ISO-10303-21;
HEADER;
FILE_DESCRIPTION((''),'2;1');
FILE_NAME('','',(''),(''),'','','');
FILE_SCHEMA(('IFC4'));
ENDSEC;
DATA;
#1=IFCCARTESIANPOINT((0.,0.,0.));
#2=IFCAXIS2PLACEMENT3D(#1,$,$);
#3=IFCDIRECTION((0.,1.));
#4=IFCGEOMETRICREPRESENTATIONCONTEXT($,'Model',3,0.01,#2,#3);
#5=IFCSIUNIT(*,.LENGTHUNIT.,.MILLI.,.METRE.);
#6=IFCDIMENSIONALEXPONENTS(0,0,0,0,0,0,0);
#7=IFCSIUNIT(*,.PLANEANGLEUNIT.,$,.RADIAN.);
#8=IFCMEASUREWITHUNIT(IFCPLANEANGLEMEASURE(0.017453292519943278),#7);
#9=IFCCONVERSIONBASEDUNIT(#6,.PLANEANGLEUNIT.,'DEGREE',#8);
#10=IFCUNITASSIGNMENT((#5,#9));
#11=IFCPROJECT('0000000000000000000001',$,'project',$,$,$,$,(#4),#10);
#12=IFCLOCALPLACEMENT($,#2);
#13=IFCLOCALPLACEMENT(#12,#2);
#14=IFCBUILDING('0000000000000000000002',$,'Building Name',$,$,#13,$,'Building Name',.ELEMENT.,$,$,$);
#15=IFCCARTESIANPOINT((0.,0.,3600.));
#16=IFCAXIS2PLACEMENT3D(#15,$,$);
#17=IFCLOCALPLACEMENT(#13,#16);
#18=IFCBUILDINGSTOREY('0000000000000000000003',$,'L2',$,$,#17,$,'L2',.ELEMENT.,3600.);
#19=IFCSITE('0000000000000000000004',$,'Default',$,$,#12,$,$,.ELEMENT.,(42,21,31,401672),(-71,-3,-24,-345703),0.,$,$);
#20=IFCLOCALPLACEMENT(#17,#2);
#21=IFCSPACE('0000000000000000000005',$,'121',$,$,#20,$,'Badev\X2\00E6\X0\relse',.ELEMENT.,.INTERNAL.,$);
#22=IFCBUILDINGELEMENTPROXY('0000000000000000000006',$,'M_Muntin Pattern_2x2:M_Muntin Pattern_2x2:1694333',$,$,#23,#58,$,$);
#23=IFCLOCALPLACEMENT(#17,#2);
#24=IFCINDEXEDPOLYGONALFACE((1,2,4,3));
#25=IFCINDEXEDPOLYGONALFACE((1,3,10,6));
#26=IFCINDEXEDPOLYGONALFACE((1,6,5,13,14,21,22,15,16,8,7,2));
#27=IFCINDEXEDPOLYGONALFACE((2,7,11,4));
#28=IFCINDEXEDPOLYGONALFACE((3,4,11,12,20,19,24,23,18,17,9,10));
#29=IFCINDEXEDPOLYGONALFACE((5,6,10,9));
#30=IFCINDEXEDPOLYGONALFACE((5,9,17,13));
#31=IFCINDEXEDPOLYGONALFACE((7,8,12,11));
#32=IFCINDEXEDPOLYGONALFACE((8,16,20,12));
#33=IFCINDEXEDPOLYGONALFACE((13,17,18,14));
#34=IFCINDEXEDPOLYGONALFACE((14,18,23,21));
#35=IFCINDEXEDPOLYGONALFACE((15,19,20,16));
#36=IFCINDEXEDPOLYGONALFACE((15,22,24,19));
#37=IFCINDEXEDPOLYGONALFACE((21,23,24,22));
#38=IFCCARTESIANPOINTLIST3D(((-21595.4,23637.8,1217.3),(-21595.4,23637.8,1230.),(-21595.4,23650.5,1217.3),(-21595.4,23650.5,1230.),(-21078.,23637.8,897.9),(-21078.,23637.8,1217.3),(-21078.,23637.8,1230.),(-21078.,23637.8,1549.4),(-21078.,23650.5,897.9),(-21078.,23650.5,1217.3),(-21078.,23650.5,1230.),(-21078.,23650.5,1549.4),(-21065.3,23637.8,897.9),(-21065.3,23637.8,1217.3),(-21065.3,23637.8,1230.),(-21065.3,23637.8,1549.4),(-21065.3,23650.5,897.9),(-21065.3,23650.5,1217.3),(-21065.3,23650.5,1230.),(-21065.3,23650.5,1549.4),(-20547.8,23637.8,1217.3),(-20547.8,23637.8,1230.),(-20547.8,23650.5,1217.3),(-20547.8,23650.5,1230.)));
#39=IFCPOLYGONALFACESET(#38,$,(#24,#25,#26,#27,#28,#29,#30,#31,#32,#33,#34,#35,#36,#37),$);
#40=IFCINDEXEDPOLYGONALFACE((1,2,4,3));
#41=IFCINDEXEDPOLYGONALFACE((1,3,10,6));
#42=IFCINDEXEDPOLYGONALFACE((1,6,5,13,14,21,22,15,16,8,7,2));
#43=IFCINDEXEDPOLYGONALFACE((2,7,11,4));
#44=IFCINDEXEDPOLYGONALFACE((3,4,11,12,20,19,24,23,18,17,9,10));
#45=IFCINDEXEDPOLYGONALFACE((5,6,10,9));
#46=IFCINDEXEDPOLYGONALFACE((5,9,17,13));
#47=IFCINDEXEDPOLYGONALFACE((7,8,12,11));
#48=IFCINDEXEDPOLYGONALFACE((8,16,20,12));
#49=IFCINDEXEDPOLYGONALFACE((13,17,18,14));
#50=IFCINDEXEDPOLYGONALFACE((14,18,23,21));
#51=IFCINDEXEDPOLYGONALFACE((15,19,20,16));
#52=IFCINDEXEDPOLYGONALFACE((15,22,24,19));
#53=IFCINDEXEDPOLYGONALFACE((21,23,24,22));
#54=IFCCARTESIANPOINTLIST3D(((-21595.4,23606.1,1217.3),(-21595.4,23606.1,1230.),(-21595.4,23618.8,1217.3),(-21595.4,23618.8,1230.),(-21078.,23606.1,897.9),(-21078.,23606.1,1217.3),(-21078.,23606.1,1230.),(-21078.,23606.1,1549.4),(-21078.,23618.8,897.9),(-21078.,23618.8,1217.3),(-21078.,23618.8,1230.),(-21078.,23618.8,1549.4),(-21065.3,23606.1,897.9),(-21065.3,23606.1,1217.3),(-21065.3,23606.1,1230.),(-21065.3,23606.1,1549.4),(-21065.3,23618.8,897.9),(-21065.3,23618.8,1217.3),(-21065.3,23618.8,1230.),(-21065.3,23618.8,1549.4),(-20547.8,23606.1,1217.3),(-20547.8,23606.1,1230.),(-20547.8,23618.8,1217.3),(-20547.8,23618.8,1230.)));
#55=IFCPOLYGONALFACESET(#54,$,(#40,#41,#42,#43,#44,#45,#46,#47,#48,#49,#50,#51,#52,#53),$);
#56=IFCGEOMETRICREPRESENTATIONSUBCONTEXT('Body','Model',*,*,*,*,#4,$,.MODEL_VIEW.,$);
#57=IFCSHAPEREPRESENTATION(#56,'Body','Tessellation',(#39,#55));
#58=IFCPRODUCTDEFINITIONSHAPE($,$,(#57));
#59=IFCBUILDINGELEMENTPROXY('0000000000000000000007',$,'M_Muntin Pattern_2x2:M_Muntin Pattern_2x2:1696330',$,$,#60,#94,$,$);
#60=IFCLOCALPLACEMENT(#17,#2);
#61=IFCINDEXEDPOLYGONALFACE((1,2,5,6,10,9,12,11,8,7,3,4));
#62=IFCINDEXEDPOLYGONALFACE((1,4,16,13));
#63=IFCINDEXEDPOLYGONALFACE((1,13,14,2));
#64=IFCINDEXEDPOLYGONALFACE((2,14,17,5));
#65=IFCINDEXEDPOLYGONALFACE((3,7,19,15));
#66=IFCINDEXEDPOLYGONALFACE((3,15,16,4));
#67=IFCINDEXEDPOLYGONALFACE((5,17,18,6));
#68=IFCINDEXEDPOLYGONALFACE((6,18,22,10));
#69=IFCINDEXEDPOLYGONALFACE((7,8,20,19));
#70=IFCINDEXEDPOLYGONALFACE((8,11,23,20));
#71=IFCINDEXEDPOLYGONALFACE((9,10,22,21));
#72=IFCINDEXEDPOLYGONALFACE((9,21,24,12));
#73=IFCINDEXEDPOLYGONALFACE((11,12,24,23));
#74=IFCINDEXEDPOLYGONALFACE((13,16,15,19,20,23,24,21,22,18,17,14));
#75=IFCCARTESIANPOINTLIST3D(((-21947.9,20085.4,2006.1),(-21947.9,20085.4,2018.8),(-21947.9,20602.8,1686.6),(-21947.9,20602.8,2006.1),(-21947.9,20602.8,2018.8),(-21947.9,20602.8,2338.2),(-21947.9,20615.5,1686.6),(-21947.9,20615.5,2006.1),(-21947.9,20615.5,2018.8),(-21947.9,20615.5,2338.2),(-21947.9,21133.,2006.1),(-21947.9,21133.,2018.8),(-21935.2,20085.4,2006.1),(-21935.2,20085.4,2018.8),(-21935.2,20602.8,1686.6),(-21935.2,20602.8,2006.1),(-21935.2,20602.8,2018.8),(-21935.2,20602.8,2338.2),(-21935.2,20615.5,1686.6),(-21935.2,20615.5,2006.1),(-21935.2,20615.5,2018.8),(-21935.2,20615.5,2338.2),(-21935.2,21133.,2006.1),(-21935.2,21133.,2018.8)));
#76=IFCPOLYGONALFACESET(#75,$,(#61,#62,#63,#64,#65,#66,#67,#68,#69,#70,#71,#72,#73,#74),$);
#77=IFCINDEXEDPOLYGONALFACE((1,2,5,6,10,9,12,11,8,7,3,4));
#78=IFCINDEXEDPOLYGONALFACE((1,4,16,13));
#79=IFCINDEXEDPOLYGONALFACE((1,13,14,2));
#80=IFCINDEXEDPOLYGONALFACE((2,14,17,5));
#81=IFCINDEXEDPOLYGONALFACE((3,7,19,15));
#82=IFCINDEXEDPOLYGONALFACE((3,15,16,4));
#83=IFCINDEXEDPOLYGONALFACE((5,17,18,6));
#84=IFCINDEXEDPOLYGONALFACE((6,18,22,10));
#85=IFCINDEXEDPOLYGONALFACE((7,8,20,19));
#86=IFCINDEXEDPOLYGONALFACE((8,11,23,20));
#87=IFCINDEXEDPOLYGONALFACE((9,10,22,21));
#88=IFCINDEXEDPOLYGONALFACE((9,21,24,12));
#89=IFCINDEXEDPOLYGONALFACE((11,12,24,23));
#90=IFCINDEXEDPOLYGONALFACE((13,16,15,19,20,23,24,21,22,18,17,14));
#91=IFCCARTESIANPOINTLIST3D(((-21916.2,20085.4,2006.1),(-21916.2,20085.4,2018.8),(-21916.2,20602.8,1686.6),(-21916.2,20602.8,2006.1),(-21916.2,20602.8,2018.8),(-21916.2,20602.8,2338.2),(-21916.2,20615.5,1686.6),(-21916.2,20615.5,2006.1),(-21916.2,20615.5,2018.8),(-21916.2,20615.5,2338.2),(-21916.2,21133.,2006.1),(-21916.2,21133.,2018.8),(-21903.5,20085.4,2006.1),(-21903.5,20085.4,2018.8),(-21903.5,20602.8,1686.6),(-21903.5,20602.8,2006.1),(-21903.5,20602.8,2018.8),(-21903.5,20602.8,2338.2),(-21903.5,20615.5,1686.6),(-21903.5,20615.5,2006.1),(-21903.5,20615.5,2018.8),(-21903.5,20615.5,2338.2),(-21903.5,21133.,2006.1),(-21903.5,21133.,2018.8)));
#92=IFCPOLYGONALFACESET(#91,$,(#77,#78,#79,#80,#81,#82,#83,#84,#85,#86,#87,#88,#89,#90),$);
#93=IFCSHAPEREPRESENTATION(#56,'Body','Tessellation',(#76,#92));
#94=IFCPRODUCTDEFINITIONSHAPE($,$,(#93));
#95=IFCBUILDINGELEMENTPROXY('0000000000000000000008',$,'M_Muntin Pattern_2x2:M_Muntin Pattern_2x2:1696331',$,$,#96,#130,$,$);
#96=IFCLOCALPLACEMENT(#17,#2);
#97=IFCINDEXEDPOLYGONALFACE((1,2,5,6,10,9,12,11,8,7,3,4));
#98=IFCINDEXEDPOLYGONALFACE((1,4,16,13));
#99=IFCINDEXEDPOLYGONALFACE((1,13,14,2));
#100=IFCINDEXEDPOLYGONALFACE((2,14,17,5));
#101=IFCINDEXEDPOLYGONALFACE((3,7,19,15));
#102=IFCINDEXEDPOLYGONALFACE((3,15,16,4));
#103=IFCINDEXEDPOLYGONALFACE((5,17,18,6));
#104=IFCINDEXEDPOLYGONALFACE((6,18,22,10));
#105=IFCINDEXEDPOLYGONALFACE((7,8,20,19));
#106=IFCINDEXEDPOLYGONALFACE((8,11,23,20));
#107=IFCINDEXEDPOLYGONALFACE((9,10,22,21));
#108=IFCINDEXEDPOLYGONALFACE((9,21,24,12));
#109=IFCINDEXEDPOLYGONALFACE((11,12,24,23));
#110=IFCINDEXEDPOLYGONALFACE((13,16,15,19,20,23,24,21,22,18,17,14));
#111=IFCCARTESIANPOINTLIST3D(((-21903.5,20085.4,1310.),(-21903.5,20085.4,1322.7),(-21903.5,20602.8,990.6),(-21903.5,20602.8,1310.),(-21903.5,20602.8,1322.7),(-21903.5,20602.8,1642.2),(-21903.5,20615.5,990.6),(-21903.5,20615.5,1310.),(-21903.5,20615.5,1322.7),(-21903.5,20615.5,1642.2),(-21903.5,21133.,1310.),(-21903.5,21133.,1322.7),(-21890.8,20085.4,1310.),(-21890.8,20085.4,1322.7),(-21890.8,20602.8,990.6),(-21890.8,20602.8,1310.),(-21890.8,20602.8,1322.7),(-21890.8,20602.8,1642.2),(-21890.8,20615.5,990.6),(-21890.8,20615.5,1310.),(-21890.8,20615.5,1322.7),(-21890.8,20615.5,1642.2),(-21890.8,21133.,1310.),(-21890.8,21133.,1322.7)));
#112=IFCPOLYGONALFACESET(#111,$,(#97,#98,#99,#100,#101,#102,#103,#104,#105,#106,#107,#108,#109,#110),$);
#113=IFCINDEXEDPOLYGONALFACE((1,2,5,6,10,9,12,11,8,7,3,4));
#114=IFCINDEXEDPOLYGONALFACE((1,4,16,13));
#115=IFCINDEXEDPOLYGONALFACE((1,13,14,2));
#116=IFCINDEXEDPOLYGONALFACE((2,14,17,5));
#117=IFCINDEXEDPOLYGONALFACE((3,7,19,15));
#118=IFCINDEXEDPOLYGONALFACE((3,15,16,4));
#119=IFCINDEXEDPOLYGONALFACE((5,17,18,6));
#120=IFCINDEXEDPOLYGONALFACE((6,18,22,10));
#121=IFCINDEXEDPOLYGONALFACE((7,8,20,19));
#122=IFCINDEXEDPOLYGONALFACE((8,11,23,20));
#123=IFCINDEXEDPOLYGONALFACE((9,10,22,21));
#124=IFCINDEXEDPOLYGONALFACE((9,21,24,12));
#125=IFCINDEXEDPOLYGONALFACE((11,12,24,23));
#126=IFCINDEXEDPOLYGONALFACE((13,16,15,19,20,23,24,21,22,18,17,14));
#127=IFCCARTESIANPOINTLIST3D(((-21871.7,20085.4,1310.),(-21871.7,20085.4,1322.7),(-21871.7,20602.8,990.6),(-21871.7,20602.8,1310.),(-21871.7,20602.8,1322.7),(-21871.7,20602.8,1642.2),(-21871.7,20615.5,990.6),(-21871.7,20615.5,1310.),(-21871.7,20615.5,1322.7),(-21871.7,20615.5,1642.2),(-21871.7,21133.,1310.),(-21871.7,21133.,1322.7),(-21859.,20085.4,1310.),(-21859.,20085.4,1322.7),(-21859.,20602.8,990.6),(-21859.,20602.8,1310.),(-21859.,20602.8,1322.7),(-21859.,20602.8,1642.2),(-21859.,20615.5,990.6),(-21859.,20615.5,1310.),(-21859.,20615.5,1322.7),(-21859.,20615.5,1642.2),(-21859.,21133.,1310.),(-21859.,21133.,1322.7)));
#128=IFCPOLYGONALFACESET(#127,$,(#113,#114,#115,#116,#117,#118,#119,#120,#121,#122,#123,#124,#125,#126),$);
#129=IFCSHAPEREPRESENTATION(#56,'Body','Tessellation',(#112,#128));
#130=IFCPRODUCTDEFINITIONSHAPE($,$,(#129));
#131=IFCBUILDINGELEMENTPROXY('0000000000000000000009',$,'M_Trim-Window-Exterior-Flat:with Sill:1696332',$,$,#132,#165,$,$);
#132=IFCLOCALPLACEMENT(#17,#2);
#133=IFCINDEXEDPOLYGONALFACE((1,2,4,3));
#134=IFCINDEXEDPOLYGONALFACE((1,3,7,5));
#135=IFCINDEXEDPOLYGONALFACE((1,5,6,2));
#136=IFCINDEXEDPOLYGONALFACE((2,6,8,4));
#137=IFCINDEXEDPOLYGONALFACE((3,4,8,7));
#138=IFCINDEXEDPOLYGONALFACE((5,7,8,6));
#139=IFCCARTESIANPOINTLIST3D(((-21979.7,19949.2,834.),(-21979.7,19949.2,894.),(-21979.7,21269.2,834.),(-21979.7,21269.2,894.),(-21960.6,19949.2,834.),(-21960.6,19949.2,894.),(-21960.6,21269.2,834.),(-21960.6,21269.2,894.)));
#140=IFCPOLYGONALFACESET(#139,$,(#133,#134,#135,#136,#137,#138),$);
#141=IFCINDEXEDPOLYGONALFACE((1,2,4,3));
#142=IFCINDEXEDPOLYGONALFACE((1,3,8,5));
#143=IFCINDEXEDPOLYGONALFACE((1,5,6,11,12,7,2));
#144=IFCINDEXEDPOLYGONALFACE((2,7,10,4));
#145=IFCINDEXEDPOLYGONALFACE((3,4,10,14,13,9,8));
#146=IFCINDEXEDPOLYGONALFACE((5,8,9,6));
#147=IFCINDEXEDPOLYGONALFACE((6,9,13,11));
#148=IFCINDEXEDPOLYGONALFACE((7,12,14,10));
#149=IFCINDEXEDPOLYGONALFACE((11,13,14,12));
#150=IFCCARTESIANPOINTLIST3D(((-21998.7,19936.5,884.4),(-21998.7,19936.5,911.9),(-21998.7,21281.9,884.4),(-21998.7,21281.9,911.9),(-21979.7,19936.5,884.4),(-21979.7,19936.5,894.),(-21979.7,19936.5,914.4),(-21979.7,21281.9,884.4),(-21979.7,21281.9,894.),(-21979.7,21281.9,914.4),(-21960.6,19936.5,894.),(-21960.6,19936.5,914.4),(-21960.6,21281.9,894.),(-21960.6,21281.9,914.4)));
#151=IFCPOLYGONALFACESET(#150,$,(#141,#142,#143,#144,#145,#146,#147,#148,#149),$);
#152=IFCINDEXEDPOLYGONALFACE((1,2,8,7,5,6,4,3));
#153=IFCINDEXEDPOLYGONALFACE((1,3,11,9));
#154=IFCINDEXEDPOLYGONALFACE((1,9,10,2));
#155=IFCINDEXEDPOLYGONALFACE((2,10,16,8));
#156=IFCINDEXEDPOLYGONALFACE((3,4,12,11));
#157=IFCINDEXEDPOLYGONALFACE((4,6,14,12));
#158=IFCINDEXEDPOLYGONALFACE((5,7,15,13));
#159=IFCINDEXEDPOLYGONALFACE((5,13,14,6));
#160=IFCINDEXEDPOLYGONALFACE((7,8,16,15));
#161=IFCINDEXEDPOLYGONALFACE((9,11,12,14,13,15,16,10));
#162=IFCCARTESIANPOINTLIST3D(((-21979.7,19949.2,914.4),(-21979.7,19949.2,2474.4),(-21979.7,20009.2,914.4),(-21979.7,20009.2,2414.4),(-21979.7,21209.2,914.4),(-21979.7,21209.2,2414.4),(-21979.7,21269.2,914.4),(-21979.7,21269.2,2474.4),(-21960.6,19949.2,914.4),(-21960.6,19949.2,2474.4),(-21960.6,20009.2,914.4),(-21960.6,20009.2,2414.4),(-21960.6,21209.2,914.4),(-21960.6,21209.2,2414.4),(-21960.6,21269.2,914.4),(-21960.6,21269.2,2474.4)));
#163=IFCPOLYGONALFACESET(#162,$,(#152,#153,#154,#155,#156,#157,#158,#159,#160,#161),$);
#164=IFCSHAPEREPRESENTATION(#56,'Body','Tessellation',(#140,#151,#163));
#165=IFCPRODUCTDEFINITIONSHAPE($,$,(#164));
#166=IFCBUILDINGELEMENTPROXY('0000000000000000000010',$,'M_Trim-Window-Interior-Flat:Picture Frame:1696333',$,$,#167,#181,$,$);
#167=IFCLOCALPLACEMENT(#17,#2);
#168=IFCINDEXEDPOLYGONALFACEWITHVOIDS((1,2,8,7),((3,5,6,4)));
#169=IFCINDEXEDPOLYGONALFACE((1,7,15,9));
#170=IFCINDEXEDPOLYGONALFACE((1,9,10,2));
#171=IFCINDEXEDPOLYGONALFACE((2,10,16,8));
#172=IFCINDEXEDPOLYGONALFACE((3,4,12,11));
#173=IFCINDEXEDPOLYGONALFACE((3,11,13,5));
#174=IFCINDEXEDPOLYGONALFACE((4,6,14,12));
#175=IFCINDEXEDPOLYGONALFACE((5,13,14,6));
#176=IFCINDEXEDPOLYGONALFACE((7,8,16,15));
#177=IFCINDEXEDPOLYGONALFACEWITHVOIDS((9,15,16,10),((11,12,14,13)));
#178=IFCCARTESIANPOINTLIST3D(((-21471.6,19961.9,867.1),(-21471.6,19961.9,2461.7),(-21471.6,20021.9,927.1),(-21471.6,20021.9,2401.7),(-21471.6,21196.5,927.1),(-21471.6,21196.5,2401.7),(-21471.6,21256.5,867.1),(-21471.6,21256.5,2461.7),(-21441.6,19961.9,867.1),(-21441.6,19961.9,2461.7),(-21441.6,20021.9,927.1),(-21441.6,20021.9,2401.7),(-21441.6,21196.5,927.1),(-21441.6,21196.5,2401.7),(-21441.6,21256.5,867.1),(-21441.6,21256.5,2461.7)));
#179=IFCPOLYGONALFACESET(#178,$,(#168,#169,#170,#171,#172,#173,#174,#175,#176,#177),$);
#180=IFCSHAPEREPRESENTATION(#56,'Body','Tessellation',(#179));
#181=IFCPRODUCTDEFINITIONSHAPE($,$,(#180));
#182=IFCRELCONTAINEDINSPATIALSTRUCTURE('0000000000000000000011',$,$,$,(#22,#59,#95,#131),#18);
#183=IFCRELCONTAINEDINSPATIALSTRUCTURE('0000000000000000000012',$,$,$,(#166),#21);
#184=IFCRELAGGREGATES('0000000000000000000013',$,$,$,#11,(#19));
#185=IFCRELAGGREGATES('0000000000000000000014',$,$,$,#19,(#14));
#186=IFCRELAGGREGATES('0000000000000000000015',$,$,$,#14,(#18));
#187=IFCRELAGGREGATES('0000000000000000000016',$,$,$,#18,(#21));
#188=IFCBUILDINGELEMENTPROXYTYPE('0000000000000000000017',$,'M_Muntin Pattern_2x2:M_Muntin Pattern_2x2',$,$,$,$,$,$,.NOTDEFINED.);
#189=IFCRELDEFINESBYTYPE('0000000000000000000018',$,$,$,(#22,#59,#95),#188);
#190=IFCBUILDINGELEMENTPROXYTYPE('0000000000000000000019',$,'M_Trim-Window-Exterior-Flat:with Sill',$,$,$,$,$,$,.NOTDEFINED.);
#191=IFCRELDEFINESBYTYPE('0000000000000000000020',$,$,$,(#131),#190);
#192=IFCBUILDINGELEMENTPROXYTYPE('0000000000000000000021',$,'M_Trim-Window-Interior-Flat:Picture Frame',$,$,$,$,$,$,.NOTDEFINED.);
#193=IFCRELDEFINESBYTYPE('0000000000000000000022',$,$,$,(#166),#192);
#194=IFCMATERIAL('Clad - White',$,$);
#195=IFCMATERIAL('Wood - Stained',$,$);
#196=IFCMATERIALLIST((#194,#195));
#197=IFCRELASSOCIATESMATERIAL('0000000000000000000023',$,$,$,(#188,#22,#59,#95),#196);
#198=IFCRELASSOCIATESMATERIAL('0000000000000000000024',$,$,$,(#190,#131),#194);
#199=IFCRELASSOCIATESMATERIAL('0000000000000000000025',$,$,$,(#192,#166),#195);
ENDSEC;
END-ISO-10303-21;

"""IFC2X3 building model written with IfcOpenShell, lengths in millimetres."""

from ifc_helpers import new_model, entity, si_unit, converted_unit, direction, frame, frame_2d, origin, place, context, subcontext, project, spatial, polyline, rectangle, outline, extrude, source, transform, mapped, material, material_list, type_object, type_shapes, element, save


model = new_model("IFC2X3")

# Units and contexts
model_context = context("Model", 3, precision=0.01, world=origin(), true_north=direction((0.0, 1.0)))
body_context = subcontext(model_context, "Body", "Model", "MODEL_VIEW")
ifc_project = project(units=[si_unit("LENGTHUNIT", "METRE", prefix="MILLI"), converted_unit("PLANEANGLEUNIT", "DEGREE", entity("IfcPlaneAngleMeasure", 0.017453292519943278), si_unit("PLANEANGLEUNIT", "RADIAN"), dimensions=[0, 0, 0, 0, 0, 0, 0])], contexts=[model_context])

# Site, building, storey
site_placement = place(None, origin())
site = spatial("IfcSite", under=ifc_project, at=site_placement, Name="Default", CompositionType="ELEMENT", RefLatitude=(42, 21, 31, 401672), RefLongitude=(-71, -3, -24, -345703), RefElevation=0.0)
building_placement = place(site_placement, origin())
building = spatial("IfcBuilding", under=site, at=building_placement, Name="Building Name", LongName="Building Name", CompositionType="ELEMENT")
storey_placement = place(building_placement, frame((0.0, 0.0, 3600.0)))
storey = spatial("IfcBuildingStorey", under=building, at=storey_placement, Name="L2", LongName="L2", CompositionType="ELEMENT", Elevation=3600.0)

# Shared definitions
ifc_material_1 = material(Name="Wood - Stained")

# Building element proxies
ifc_material_2 = material(Name="Clad - White")
ifc_material_list_1 = material_list([ifc_material_2, ifc_material_1])
building_element_proxy_type_1 = type_object("IfcBuildingElementProxyType", Name="M_Muntin Pattern_2x2:M_Muntin Pattern_2x2", PredefinedType="NOTDEFINED", material=ifc_material_list_1)
shared_shape_1 = source(origin(), body_context, "Body", "SweptSolid", [
    extrude(outline(polyline([(6.4, -6.4), (325.8, -6.4), (325.8, 6.3), (6.4, 6.3), (6.4, 523.8), (-6.3, 523.8), (-6.3, 6.3), (-325.8, 6.3), (-325.8, -6.4), (-6.3, -6.4), (-6.3, -523.8), (6.4, -523.8), (6.4, -6.4)])), frame((0.0, 9.5, 325.8), z_axis=(0.0, 1.0, 0.0), x_axis=(0.0, 0.0, 1.0)), (0.0, 0.0, 1.0), 12.7),
    extrude(outline(polyline([(6.4, -6.4), (325.8, -6.4), (325.8, 6.3), (6.4, 6.3), (6.4, 523.8), (-6.3, 523.8), (-6.3, 6.3), (-325.8, 6.3), (-325.8, -6.4), (-6.3, -6.4), (-6.3, -523.8), (6.4, -523.8), (6.4, -6.4)])), frame((0.0, -22.2, 325.8), z_axis=(0.0, 1.0, 0.0), x_axis=(0.0, 0.0, 1.0)), (0.0, 0.0, 1.0), 12.7),
])
type_shapes(building_element_proxy_type_1, [shared_shape_1])
for number, where, name in (
    (1, (-21071.6, 23628.3, 897.9), "M_Muntin Pattern_2x2:M_Muntin Pattern_2x2:1694333"),
):
    element("IfcBuildingElementProxy", number, at=place(storey_placement, frame(where)), inside=storey, type_object=building_element_proxy_type_1, material=ifc_material_list_1, Name=name, context=body_context, shape_type="MappedRepresentation", body=[
        mapped(shared_shape_1, transform((0.0, 0.0, 0.0), scale=1.0)),
    ])
for number, where, z_axis, x_axis, name in (
    (2, (-21925.7, 20609.2, 1686.6), (0.0, 0.0, 1.0), (0.0, 1.0, 0.0), "M_Muntin Pattern_2x2:M_Muntin Pattern_2x2:1696330"),
    (3, (-21881.3, 20609.2, 990.6), (0.0, 0.0, 1.0), (0.0, 1.0, 0.0), "M_Muntin Pattern_2x2:M_Muntin Pattern_2x2:1696331"),
):
    element("IfcBuildingElementProxy", number, at=place(storey_placement, frame(where, z_axis=z_axis, x_axis=x_axis)), inside=storey, type_object=building_element_proxy_type_1, material=ifc_material_list_1, Name=name, context=body_context, shape_type="MappedRepresentation", body=[
        mapped(shared_shape_1, transform((0.0, 0.0, 0.0), scale=1.0)),
    ])
building_element_proxy_type_2 = type_object("IfcBuildingElementProxyType", Name="M_Trim-Window-Exterior-Flat:with Sill", PredefinedType="NOTDEFINED", material=ifc_material_2)
shared_shape_2 = source(origin(), body_context, "Body", "SweptSolid", [
    extrude(rectangle(XDim=1320.0, YDim=60.0, at=frame_2d((0.0, 0.0), x_axis=(1.0, 0.0))), frame((0.0, -1550.4, 0.0), z_axis=(0.0, 0.0, 1.0), x_axis=(-1.0, 0.0, 0.0)), (0.0, 0.0, 1.0), 19.0),
    extrude(outline(polyline([(-19.0, -15.2), (0.0, -15.2), (0.0, -5.7), (19.0, -5.7), (19.0, 14.8), (0.0, 14.8), (-19.0, 12.3), (-19.0, -15.2)])), frame((-672.7, -1514.8, 19.0), z_axis=(1.0, 0.0, 0.0), x_axis=(0.0, 0.0, -1.0)), (0.0, 0.0, 1.0), 1345.4),
    extrude(outline(polyline([(-795.0, -660.0), (765.0, -660.0), (765.0, -600.0), (-735.0, -600.0), (-735.0, 600.0), (765.0, 600.0), (765.0, 660.0), (-795.0, 660.0), (-795.0, -660.0)])), frame((0.0, -735.0, 0.0), z_axis=(0.0, 0.0, 1.0), x_axis=(0.0, -1.0, 0.0)), (0.0, 0.0, 1.0), 19.0),
])
type_shapes(building_element_proxy_type_2, [shared_shape_2])
proxy_1_placement = place(storey_placement, frame((-21960.6, 20609.2, 2414.4), z_axis=(-1.0, 0.0, 0.0), x_axis=(0.0, -1.0, 0.0)))
element("IfcBuildingElementProxy", 4, at=proxy_1_placement, inside=storey, type_object=building_element_proxy_type_2, material=ifc_material_2, Name="M_Trim-Window-Exterior-Flat:with Sill:1696332", context=body_context, shape_type="MappedRepresentation", body=[
    mapped(shared_shape_2, transform((0.0, 0.0, 0.0), scale=1.0)),
])

# Shared definitions
space_placement = place(storey_placement, origin())
space = spatial("IfcSpace", under=storey, at=space_placement, Name="121", LongName="Badeværelse", CompositionType="ELEMENT", InteriorOrExteriorSpace="INTERNAL")

# Building element proxy
building_element_proxy_type_3 = type_object("IfcBuildingElementProxyType", Name="M_Trim-Window-Interior-Flat:Picture Frame", PredefinedType="NOTDEFINED", material=ifc_material_1)
shared_shape_3 = source(origin(), body_context, "Body", "SweptSolid", [
    extrude(outline(polyline([(-647.3, -797.3), (647.3, -797.3), (647.3, 797.3), (-647.3, 797.3), (-647.3, -797.3)]), holes=[polyline([(-587.3, -737.3), (-587.3, 737.3), (587.3, 737.3), (587.3, -737.3), (-587.3, -737.3)])]), frame((0.0, -750.0, 0.0), z_axis=(0.0, 0.0, 1.0), x_axis=(-1.0, 0.0, 0.0)), (0.0, 0.0, 1.0), 30.0),
])
type_shapes(building_element_proxy_type_3, [shared_shape_3])
proxy_2_placement = place(space_placement, frame((-21471.6, 20609.2, 2414.4), z_axis=(1.0, 0.0, 0.0), x_axis=(0.0, 1.0, 0.0)))
element("IfcBuildingElementProxy", 5, at=proxy_2_placement, inside=space, type_object=building_element_proxy_type_3, material=ifc_material_1, Name="M_Trim-Window-Interior-Flat:Picture Frame:1696333", context=body_context, shape_type="MappedRepresentation", body=[
    mapped(shared_shape_3, transform((0.0, 0.0, 0.0), scale=1.0)),
])

save(model, "model.ifc")
